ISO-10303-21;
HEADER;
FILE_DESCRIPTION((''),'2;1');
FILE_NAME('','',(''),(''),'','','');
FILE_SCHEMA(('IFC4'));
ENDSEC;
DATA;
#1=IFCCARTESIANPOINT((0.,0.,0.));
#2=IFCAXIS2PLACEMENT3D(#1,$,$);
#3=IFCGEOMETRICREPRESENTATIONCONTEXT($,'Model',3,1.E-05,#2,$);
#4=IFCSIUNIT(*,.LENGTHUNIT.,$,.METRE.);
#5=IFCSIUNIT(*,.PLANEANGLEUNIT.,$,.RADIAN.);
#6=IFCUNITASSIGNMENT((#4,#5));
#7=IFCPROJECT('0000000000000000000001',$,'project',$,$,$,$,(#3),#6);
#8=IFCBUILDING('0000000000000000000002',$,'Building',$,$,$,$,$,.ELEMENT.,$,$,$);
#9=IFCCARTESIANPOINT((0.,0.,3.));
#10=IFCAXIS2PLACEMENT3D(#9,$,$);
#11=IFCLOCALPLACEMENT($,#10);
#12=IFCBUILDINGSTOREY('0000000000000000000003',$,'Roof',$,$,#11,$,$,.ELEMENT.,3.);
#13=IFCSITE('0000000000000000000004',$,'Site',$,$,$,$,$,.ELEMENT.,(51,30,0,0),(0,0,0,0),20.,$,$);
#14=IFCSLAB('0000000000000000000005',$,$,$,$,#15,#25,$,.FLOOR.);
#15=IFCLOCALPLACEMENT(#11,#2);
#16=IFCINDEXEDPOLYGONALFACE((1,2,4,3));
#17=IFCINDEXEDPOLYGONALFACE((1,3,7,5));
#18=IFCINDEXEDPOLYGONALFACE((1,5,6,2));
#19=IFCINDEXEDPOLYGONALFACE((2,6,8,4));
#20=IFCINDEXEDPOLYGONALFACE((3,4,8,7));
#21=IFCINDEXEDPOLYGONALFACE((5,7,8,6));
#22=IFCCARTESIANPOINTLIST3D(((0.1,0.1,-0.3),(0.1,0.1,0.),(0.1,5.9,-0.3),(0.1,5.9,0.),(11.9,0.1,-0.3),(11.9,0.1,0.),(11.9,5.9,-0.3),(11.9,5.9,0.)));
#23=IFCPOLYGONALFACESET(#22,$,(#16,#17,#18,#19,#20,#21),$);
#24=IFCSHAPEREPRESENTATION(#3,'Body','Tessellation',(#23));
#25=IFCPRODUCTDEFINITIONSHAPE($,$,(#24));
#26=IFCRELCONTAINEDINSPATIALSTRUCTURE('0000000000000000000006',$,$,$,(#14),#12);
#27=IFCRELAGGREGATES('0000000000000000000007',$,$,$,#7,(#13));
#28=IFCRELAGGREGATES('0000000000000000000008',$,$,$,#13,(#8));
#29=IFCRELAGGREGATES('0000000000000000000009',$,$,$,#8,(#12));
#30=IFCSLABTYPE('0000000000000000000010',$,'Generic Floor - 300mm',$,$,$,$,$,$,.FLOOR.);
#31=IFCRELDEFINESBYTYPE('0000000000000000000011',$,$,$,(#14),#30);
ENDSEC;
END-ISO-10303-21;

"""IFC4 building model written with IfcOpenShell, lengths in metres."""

from ifc_helpers import new_model, si_unit, frame, origin, place, context, project, spatial, polyline, outline, extrude, type_object, element, save


model = new_model("IFC4")

# Units and contexts
model_context = context("Model", 3, precision=1e-05, world=origin())
ifc_project = project(units=[si_unit("LENGTHUNIT", "METRE"), si_unit("PLANEANGLEUNIT", "RADIAN")], contexts=[model_context])

# Site, building, storey
site = spatial("IfcSite", under=ifc_project, Name="Site", CompositionType="ELEMENT", RefLatitude=(51, 30, 0, 0), RefLongitude=(0, 0, 0, 0), RefElevation=20.0)
building = spatial("IfcBuilding", under=site, Name="Building", CompositionType="ELEMENT")
storey_placement = place(None, frame((0.0, 0.0, 3.0)))
storey = spatial("IfcBuildingStorey", under=building, at=storey_placement, Name="Roof", CompositionType="ELEMENT", Elevation=3.0)

# Slab
slab_type = type_object("IfcSlabType", Name="Generic Floor - 300mm", PredefinedType="FLOOR")
slab_placement = place(None, frame((0.0, 0.0, 3.0)))
element("IfcSlab", 1, at=slab_placement, inside=storey, type_object=slab_type, PredefinedType="FLOOR", context=model_context, shape_type="SweptSolid", body=[
    extrude(outline(polyline([(0.1, 0.1), (11.9, 0.1), (11.9, 5.9), (0.1, 5.9), (0.1, 0.1)])), origin(), (0.0, 0.0, -1.0), 0.3),
])

save(model, "model.ifc")
